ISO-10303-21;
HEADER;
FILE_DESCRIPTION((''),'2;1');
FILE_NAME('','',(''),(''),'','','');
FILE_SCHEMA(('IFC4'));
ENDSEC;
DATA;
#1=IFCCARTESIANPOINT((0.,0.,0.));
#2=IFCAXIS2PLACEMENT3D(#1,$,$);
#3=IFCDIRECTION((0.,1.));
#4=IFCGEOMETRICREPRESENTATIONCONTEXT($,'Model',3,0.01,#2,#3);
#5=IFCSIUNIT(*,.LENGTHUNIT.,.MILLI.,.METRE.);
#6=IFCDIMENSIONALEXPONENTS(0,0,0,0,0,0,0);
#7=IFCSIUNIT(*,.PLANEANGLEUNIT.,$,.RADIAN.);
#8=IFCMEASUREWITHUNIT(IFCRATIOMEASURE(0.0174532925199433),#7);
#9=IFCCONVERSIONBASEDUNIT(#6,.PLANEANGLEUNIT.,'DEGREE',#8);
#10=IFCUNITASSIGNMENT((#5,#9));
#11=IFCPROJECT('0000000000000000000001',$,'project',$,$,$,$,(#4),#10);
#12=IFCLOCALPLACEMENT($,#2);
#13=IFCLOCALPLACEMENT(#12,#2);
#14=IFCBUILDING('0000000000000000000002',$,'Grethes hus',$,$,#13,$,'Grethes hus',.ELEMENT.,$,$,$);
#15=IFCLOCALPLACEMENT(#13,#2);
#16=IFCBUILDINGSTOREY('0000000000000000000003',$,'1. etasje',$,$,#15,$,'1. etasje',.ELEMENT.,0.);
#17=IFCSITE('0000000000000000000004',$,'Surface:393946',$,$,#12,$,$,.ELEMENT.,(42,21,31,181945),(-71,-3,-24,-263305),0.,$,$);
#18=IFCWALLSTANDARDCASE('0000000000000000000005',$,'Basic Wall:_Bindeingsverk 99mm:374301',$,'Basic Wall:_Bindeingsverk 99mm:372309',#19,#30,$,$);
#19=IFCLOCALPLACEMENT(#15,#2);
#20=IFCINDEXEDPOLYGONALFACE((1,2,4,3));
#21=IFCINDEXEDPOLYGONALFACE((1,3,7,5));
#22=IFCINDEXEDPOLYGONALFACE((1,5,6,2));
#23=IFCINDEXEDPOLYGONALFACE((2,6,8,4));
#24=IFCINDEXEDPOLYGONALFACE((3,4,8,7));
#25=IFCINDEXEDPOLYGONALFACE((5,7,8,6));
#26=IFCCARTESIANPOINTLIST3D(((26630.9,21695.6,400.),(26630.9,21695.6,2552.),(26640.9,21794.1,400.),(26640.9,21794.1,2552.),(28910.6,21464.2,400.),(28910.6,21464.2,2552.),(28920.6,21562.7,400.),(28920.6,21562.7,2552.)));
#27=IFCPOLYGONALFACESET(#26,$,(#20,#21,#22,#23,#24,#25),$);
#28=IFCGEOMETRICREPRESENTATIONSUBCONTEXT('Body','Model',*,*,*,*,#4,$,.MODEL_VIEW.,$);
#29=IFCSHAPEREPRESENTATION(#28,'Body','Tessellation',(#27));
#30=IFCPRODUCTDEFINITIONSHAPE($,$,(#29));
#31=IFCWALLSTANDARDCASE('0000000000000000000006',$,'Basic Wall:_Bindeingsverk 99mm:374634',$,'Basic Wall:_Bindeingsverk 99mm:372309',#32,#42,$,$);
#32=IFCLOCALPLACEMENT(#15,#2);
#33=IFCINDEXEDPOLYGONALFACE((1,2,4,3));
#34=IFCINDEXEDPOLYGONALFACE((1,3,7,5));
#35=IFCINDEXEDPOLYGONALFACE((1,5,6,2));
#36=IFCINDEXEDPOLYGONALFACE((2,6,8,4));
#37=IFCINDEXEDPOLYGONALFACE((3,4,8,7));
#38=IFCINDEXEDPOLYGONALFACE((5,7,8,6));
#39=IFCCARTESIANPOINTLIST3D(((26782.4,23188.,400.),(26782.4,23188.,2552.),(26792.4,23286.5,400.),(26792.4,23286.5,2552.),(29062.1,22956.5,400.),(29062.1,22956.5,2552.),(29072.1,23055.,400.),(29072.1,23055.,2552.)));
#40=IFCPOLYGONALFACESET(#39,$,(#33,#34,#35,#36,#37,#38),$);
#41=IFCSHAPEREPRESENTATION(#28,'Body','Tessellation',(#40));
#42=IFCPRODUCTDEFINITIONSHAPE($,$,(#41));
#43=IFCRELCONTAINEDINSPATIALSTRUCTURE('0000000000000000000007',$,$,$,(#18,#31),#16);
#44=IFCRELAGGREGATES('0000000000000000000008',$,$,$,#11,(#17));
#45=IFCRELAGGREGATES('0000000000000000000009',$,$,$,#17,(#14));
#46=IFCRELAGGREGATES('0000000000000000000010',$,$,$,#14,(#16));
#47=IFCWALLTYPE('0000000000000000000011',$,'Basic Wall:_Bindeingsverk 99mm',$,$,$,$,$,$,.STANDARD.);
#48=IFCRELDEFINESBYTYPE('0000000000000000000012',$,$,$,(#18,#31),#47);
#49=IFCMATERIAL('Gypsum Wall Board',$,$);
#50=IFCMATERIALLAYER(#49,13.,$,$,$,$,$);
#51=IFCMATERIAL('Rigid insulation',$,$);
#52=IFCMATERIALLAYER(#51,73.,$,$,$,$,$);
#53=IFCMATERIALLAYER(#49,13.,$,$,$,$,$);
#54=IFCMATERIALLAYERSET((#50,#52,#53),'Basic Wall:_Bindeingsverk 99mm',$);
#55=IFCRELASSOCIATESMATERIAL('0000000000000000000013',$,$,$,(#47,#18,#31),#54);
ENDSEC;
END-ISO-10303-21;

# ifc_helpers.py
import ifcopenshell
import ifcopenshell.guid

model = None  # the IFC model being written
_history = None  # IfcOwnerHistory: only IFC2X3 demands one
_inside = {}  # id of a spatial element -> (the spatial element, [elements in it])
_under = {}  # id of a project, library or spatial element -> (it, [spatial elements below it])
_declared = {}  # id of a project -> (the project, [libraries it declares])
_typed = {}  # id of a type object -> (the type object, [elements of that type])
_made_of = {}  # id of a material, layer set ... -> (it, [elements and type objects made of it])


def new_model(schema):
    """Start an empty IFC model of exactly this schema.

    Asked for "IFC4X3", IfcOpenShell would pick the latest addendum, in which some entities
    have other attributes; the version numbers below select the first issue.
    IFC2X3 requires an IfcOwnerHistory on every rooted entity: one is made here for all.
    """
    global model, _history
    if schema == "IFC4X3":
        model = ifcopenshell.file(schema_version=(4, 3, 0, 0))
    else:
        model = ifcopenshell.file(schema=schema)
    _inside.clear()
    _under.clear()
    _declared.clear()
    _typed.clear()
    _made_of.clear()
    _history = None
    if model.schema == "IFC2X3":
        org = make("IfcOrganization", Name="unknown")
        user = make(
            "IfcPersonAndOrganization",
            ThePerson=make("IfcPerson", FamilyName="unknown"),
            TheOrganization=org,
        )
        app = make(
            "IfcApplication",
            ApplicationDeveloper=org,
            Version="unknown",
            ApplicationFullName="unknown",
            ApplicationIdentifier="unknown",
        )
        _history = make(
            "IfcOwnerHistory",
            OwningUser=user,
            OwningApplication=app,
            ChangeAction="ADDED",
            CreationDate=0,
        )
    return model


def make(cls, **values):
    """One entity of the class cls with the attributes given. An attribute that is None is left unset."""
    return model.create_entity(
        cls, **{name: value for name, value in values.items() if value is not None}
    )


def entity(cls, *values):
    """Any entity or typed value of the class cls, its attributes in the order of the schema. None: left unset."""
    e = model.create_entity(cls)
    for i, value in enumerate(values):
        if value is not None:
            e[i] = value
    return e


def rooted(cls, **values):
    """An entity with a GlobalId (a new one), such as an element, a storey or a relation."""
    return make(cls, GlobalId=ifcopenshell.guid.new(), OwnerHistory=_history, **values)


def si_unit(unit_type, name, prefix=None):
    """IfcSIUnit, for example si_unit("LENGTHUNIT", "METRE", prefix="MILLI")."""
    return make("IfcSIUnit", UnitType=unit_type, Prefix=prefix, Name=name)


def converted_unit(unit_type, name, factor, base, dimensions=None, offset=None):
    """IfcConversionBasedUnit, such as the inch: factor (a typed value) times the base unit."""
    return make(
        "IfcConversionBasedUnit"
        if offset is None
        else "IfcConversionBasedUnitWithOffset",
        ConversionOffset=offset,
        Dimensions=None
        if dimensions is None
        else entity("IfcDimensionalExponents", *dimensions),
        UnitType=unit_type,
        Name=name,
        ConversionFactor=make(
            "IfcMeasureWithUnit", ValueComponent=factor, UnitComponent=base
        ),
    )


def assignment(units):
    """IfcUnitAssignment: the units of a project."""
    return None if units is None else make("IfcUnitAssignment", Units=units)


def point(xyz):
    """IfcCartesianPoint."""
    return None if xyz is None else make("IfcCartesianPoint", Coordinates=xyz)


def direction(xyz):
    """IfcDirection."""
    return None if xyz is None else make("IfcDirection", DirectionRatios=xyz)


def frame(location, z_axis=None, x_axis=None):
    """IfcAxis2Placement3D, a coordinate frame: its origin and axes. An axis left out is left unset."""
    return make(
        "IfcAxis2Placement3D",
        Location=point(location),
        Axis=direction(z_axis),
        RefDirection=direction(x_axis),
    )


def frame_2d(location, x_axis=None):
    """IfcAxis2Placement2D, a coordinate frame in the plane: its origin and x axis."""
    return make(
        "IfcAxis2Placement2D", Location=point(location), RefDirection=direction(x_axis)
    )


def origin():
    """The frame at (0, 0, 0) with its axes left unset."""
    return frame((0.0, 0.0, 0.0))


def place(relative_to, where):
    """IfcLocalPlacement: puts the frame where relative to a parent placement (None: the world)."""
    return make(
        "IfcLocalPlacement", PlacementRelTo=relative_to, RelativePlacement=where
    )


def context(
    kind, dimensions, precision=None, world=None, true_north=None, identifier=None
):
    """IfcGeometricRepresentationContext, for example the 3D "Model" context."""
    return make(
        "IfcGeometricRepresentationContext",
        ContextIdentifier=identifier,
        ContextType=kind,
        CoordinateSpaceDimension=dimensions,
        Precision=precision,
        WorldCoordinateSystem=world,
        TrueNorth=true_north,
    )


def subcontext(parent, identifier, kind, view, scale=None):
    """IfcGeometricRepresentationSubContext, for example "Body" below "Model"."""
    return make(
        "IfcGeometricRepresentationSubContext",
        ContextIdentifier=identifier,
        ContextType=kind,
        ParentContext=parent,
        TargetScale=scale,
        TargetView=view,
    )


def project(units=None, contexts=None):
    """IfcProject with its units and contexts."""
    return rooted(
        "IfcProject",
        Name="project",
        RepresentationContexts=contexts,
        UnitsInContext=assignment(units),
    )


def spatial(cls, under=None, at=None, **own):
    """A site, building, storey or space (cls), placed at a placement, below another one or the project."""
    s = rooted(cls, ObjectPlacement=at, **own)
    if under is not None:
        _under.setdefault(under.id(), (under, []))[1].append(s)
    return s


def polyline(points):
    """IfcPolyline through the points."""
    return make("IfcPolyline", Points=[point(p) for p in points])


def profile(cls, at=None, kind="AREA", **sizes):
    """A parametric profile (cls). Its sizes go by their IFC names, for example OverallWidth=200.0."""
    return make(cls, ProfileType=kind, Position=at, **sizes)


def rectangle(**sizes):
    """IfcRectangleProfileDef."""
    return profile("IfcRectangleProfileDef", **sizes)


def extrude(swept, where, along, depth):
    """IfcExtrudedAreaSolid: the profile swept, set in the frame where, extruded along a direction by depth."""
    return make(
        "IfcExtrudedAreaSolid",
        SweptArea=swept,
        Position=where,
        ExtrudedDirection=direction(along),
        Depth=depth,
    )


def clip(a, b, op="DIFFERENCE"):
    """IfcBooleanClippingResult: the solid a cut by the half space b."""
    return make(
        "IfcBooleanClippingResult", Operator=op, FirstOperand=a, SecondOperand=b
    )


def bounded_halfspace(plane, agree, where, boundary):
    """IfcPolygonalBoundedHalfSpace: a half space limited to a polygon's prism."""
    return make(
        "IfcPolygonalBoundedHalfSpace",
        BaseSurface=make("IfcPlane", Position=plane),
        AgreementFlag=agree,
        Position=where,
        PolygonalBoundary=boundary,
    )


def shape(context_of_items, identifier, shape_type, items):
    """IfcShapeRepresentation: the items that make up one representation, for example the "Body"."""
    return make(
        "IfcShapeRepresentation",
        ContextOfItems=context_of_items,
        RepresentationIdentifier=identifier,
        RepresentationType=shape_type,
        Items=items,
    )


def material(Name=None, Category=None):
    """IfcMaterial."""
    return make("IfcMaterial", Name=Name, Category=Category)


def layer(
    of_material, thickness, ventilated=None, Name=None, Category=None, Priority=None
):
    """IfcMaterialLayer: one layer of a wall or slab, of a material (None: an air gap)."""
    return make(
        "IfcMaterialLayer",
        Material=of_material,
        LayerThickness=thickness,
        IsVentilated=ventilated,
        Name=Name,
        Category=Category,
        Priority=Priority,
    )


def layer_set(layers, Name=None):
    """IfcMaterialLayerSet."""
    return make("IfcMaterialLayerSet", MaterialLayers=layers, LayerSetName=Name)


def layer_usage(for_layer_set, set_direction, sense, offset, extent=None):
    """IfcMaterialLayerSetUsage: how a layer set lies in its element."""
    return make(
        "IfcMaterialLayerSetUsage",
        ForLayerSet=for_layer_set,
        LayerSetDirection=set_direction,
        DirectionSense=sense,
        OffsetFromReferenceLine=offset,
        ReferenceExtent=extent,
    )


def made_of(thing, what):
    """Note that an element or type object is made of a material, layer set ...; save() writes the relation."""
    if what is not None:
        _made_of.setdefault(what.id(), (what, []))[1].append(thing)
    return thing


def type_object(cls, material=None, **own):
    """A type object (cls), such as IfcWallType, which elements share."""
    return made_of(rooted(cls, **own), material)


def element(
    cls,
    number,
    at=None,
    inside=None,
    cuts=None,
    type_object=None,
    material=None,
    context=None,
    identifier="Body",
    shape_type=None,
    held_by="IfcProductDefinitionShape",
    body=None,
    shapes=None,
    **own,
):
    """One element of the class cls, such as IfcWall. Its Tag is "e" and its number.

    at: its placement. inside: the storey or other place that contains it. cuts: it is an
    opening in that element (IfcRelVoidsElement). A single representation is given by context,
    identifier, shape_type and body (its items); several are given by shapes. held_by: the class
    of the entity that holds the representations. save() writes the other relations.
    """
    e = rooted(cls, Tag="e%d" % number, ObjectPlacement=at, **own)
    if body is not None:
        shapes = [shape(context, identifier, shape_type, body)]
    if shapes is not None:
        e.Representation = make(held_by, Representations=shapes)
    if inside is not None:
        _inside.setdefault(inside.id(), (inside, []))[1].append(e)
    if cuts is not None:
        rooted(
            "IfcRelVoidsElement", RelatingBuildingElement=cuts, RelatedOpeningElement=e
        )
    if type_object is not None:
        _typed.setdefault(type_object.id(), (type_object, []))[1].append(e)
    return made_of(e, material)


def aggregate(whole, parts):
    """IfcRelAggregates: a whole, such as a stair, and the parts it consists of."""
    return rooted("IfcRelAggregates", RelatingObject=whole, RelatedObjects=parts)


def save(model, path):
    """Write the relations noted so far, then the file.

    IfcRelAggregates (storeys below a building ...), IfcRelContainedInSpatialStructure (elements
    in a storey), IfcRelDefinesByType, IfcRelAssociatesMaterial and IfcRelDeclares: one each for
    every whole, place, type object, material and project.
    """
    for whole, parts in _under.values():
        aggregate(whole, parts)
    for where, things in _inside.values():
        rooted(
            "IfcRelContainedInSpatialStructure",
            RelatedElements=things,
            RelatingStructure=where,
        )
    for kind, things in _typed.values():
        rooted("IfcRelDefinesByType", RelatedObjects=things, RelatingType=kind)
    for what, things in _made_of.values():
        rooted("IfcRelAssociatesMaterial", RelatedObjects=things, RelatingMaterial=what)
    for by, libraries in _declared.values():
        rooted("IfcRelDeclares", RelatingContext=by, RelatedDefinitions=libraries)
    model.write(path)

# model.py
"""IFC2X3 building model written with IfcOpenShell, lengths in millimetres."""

from ifc_helpers import new_model, entity, si_unit, converted_unit, direction, frame, frame_2d, origin, place, context, subcontext, project, spatial, polyline, rectangle, extrude, clip, bounded_halfspace, material, layer, layer_set, layer_usage, type_object, element, save


model = new_model("IFC2X3")

# Units and contexts
model_context = context("Model", 3, precision=0.01, world=origin(), true_north=direction((0.0, 1.0)))
body_context = subcontext(model_context, "Body", "Model", "MODEL_VIEW")
ifc_project = project(units=[si_unit("LENGTHUNIT", "METRE", prefix="MILLI"), converted_unit("PLANEANGLEUNIT", "DEGREE", entity("IfcRatioMeasure", 0.0174532925199433), si_unit("PLANEANGLEUNIT", "RADIAN"), dimensions=[0, 0, 0, 0, 0, 0, 0])], contexts=[model_context])

# Site, building, storey
site_placement = place(None, origin())
site = spatial("IfcSite", under=ifc_project, at=site_placement, Name="Surface:393946", CompositionType="ELEMENT", RefLatitude=(42, 21, 31, 181945), RefLongitude=(-71, -3, -24, -263305), RefElevation=0.0)
building_placement = place(site_placement, origin())
building = spatial("IfcBuilding", under=site, at=building_placement, Name="Grethes hus", LongName="Grethes hus", CompositionType="ELEMENT")
storey_placement = place(building_placement, origin())
storey = spatial("IfcBuildingStorey", under=building, at=storey_placement, Name="1. etasje", LongName="1. etasje", CompositionType="ELEMENT", Elevation=0.0)

# Shared definitions
ifc_material_1 = material(Name="Gypsum Wall Board")
ifc_material_2 = material(Name="Rigid insulation")

# Walls
ifc_layer_1 = layer(ifc_material_1, 13.0)
ifc_layer_2 = layer(ifc_material_2, 73.0)
ifc_layer_3 = layer(ifc_material_1, 13.0)
ifc_layer_set_1 = layer_set([ifc_layer_1, ifc_layer_2, ifc_layer_3], Name="Basic Wall:_Bindeingsverk 99mm")
ifc_layer_usage_1 = layer_usage(ifc_layer_set_1, "AXIS2", "NEGATIVE", 49.5)
wall_type_1 = type_object("IfcWallType", Name="Basic Wall:_Bindeingsverk 99mm", PredefinedType="STANDARD", material=ifc_layer_set_1)
wall_1_placement = place(storey_placement, frame((28915.6, 21513.4, 400.0), z_axis=(0.0, 0.0, 1.0), x_axis=(-0.994887, 0.100996, 0.0)))
element("IfcWallStandardCase", 1, at=wall_1_placement, inside=storey, type_object=wall_type_1, material=ifc_layer_usage_1, Name="Basic Wall:_Bindeingsverk 99mm:374301", ObjectType="Basic Wall:_Bindeingsverk 99mm:372309", context=body_context, shape_type="Clipping", body=[
    clip(extrude(rectangle(XDim=2291.5, YDim=99.0, at=frame_2d((1145.7, 0.0), x_axis=(-1.0, 0.0))), origin(), (0.0, 0.0, 1.0), 2152.0), bounded_halfspace(frame((0.0, -49.5, 2152.0), z_axis=(0.0, 0.0, -1.0), x_axis=(-1.0, 0.0, 0.0)), True, frame((0.0, -49.5, 2152.0)), polyline([(0.0, 0.0), (2291.5, 0.0), (2291.5, 99.0), (0.0, 99.0), (0.0, 0.0)]))),
])
ifc_layer_usage_2 = layer_usage(ifc_layer_set_1, "AXIS2", "NEGATIVE", 49.5)
wall_2_placement = place(storey_placement, frame((29067.1, 23005.8, 400.0), z_axis=(0.0, 0.0, 1.0), x_axis=(-0.994887, 0.100996, 0.0)))
element("IfcWallStandardCase", 2, at=wall_2_placement, inside=storey, type_object=wall_type_1, material=ifc_layer_usage_2, Name="Basic Wall:_Bindeingsverk 99mm:374634", ObjectType="Basic Wall:_Bindeingsverk 99mm:372309", context=body_context, shape_type="Clipping", body=[
    clip(extrude(rectangle(XDim=2291.5, YDim=99.0, at=frame_2d((1145.7, 0.0), x_axis=(-1.0, 0.0))), origin(), (0.0, 0.0, 1.0), 2152.0), bounded_halfspace(frame((0.0, -49.5, 2152.0), z_axis=(0.0, 0.0, -1.0), x_axis=(-1.0, 0.0, 0.0)), True, frame((0.0, -49.5, 2152.0)), polyline([(0.0, 0.0), (2291.5, 0.0), (2291.5, 99.0), (0.0, 99.0), (0.0, 0.0)]))),
])

save(model, "model.ifc")
